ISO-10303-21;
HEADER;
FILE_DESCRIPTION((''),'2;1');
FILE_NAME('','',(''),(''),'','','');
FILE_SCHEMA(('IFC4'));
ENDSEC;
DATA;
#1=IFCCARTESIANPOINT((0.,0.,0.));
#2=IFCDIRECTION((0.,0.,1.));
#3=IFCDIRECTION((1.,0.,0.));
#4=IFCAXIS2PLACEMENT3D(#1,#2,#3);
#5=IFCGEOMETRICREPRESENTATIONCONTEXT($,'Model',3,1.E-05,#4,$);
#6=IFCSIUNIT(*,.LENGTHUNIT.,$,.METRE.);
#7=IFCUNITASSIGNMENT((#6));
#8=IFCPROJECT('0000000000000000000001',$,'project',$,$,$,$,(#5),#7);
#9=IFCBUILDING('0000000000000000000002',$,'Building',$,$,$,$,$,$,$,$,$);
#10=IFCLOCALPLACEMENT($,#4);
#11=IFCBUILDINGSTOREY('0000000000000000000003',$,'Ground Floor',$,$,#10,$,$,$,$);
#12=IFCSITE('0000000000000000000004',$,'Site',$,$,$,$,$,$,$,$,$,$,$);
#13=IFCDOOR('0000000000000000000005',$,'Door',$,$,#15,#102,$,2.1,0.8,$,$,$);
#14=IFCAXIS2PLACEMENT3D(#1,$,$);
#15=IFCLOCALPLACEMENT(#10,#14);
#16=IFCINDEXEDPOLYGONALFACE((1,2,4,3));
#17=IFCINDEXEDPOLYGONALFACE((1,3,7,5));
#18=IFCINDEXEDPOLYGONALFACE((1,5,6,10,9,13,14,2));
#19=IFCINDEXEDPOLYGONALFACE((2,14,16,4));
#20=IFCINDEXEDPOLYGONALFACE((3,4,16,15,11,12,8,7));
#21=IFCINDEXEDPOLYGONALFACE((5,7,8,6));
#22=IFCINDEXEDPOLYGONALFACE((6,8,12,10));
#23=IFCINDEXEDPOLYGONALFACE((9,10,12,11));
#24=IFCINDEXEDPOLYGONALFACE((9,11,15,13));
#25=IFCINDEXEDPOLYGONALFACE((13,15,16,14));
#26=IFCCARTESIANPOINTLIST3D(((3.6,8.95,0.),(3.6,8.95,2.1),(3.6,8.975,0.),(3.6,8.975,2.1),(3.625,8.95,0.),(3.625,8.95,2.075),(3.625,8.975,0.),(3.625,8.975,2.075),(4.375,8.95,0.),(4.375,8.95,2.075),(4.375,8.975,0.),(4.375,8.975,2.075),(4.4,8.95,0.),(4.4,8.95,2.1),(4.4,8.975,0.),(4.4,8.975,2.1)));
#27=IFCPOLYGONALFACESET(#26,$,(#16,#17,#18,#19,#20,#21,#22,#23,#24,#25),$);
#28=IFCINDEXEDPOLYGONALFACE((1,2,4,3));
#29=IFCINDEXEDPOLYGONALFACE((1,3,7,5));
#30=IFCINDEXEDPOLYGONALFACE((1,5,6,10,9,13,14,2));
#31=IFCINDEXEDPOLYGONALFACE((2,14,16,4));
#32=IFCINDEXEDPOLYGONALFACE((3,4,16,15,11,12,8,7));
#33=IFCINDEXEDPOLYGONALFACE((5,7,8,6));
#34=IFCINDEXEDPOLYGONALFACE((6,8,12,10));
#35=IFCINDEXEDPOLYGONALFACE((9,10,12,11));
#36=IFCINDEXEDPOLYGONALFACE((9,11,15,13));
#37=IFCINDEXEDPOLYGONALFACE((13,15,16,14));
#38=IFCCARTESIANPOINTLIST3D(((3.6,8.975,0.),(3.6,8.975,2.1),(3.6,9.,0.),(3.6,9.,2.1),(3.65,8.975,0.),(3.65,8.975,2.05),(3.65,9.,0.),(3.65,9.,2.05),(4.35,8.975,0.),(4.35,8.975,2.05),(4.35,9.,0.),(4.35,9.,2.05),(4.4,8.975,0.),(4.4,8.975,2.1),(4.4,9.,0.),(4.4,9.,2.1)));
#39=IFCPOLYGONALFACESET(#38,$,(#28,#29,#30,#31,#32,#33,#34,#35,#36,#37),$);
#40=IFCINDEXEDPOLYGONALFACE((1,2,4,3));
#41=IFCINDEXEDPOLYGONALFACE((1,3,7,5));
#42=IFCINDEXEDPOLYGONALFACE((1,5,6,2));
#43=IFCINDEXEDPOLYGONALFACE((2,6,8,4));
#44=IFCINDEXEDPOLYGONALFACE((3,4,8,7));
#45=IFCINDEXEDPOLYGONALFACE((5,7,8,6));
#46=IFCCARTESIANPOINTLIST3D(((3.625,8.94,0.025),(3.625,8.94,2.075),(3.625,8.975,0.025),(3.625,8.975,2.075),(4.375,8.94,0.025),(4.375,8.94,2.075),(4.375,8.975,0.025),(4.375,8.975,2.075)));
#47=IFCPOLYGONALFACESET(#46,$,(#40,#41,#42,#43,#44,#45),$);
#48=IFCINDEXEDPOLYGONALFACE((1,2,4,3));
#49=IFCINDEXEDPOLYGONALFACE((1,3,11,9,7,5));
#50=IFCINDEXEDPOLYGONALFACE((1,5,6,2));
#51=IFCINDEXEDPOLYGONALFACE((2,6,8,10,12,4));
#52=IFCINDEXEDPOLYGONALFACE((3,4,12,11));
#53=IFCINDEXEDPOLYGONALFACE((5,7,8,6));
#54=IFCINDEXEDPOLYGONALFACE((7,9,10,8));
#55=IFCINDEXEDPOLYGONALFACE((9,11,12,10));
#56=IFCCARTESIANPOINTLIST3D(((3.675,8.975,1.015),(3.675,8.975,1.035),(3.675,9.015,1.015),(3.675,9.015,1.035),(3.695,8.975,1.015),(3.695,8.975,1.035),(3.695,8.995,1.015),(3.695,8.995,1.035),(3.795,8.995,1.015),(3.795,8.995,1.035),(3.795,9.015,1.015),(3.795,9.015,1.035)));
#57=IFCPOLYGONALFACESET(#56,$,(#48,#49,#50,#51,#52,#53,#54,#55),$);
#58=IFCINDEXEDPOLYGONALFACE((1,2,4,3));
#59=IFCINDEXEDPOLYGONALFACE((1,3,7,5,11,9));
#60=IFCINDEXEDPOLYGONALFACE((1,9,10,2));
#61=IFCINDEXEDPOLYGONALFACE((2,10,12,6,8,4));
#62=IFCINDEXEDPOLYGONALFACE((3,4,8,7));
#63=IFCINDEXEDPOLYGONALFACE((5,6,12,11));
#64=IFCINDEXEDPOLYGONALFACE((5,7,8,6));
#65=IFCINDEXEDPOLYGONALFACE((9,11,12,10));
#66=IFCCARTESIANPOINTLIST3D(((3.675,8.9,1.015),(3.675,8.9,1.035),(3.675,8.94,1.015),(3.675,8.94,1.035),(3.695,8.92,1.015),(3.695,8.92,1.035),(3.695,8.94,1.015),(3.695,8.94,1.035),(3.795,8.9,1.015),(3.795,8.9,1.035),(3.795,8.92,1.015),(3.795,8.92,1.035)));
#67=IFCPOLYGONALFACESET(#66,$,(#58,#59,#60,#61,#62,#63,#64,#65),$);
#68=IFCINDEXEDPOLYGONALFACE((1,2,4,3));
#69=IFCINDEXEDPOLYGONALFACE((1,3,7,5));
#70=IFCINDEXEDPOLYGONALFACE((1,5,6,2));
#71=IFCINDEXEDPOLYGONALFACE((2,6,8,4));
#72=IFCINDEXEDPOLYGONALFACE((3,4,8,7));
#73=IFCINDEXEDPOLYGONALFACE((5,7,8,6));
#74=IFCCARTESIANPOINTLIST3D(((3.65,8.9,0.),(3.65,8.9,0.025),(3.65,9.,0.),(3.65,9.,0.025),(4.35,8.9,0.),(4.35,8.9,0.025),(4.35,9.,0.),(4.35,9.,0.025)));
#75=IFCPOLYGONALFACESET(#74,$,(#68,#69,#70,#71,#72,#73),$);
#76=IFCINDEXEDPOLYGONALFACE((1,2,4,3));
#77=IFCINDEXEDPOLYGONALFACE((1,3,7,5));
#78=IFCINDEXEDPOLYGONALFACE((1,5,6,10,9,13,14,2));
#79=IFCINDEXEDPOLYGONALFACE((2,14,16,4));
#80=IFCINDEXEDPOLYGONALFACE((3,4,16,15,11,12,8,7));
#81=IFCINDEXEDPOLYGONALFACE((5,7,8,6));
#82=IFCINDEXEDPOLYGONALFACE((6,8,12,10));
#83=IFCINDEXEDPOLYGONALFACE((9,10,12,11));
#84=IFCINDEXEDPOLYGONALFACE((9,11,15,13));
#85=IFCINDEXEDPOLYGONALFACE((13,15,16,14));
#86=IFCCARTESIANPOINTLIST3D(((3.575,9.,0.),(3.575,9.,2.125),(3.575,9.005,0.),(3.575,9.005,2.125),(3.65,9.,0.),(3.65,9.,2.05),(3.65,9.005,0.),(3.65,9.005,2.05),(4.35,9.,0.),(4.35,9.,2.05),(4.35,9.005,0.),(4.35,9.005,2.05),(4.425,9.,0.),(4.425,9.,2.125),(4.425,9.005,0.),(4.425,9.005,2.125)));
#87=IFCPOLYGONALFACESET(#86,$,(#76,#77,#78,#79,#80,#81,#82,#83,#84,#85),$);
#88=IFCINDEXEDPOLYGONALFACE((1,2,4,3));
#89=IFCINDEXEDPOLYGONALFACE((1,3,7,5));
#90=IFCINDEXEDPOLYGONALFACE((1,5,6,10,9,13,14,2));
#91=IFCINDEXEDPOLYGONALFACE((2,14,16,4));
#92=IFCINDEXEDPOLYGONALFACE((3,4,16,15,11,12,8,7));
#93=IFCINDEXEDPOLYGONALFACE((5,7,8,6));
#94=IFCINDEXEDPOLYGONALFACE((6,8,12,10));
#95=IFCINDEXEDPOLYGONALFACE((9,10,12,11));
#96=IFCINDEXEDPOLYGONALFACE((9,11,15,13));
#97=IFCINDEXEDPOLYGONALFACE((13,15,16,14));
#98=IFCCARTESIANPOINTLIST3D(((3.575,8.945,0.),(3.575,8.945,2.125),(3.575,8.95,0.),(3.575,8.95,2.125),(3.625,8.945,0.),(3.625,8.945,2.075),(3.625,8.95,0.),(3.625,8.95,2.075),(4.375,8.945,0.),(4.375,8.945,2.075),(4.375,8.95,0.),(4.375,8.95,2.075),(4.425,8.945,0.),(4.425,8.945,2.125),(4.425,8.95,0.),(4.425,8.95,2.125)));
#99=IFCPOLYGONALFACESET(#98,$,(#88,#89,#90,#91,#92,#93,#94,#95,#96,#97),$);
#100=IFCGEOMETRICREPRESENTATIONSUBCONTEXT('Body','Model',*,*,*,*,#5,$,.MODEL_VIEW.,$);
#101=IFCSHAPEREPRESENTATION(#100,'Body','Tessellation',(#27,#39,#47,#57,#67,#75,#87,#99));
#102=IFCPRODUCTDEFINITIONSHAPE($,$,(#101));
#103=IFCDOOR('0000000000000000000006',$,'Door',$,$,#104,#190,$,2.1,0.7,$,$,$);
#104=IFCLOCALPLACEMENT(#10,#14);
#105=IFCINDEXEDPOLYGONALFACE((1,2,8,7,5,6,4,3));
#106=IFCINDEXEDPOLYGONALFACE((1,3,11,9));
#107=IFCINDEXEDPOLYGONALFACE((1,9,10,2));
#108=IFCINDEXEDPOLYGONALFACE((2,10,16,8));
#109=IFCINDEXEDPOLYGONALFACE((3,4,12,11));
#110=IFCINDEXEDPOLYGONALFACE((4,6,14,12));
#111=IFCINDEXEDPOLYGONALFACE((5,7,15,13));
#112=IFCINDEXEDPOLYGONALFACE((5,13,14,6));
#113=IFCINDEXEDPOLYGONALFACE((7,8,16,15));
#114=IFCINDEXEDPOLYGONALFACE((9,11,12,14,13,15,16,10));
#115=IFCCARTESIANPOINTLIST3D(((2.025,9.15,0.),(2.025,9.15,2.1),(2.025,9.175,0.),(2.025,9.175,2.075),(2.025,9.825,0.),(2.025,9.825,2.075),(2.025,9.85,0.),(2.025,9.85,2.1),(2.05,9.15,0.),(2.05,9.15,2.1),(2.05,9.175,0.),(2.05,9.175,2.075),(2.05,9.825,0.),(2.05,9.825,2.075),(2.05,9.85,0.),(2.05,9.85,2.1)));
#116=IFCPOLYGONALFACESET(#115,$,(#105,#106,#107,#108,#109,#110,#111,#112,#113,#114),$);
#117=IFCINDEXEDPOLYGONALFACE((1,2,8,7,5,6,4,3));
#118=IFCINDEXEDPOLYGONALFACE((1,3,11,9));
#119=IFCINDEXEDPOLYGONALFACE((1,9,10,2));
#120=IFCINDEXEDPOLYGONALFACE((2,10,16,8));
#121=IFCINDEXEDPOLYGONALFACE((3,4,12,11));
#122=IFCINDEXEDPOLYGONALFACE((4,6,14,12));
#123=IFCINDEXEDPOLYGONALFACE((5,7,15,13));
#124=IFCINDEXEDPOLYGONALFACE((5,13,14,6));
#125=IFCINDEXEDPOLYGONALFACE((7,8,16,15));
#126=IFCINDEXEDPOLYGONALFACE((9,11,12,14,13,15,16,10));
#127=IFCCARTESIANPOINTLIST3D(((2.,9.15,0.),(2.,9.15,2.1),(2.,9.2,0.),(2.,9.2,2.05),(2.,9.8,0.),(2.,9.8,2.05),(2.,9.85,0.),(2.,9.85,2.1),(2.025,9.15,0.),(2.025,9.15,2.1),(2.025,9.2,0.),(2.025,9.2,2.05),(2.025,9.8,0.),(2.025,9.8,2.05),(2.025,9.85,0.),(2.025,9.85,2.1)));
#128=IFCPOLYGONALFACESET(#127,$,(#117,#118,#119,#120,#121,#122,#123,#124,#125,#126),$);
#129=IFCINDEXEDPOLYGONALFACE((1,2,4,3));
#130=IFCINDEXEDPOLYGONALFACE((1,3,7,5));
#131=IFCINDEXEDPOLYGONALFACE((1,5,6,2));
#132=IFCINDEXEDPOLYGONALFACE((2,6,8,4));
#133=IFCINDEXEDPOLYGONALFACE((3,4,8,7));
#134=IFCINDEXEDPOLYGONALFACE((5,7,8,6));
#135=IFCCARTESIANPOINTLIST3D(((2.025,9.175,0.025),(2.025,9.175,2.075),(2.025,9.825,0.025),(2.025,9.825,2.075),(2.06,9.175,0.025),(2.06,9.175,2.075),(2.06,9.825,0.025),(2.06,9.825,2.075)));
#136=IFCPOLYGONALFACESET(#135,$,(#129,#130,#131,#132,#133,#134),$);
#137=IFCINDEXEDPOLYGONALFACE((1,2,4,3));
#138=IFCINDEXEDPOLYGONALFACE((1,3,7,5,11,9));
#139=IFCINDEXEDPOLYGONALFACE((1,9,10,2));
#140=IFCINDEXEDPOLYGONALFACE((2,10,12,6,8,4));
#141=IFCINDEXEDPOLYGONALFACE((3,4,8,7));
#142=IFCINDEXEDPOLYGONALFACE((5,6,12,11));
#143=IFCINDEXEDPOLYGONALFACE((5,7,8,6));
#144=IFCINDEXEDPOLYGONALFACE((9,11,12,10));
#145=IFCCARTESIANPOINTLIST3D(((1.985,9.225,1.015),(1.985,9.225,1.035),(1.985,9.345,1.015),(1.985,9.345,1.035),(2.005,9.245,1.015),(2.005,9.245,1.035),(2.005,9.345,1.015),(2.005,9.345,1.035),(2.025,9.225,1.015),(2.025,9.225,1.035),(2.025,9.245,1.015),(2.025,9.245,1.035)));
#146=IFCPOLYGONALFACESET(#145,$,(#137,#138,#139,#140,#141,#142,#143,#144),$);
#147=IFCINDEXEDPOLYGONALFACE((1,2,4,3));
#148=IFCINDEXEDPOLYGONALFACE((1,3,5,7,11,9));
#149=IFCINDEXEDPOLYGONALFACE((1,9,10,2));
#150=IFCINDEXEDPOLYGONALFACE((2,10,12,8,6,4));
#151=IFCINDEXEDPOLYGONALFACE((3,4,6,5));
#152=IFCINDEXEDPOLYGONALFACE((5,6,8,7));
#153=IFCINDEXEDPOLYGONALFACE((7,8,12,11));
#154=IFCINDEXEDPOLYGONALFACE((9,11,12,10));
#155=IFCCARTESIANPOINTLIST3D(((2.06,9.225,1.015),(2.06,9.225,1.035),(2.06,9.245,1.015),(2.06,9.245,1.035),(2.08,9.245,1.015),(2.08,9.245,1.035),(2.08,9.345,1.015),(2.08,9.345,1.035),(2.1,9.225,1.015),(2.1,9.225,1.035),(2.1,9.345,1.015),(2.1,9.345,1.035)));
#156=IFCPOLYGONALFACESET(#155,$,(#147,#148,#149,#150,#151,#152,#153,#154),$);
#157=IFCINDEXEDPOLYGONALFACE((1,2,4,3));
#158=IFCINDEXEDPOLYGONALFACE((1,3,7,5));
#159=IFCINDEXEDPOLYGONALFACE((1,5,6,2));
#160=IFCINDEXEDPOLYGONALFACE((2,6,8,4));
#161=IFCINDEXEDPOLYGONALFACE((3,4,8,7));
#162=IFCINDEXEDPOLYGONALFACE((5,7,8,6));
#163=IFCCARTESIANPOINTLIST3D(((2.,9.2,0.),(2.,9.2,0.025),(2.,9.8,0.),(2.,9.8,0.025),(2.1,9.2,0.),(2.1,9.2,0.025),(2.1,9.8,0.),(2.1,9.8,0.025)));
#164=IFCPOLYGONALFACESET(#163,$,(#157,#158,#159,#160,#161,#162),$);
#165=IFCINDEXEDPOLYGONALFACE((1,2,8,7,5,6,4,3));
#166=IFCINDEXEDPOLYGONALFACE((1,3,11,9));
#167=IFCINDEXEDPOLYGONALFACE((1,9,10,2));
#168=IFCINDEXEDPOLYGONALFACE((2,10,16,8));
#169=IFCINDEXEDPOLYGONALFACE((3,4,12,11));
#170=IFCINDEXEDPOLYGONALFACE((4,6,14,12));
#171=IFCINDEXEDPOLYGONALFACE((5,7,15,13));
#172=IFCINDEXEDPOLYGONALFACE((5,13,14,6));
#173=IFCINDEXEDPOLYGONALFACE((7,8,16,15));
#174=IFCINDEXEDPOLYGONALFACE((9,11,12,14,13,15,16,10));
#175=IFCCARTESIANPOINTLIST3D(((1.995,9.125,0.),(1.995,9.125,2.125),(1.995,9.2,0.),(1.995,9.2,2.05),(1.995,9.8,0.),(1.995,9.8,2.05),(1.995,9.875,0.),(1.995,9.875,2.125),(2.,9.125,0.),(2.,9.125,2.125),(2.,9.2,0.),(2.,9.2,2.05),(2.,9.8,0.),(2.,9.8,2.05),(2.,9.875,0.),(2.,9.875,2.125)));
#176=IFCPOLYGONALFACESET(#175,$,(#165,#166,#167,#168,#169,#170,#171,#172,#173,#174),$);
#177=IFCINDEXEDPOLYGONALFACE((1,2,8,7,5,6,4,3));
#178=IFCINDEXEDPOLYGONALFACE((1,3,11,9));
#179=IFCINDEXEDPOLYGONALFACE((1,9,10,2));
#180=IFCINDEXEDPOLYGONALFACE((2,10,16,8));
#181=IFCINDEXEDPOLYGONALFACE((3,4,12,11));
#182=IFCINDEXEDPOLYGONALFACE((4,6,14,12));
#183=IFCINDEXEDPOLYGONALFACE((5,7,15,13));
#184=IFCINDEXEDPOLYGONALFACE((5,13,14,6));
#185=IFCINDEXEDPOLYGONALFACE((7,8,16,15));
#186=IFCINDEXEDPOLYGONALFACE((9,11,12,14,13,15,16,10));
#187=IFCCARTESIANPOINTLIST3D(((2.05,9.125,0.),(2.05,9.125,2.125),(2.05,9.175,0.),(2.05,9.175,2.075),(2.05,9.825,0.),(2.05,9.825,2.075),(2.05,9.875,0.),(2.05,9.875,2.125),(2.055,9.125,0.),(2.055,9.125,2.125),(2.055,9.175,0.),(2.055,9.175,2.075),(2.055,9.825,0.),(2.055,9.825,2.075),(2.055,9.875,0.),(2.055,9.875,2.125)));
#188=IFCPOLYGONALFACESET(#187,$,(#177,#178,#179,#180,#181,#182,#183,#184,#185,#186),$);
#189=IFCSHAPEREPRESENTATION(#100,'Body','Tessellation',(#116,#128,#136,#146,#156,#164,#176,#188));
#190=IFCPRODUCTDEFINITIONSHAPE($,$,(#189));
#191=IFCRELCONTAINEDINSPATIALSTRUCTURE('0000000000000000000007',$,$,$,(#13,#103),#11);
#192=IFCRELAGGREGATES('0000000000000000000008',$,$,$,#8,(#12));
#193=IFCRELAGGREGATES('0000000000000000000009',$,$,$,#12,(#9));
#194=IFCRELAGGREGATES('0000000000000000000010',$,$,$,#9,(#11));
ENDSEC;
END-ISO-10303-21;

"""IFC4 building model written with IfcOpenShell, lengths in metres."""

from ifc_helpers import new_model, si_unit, frame, origin_with_axes, place, context, subcontext, project, spatial, line, indexed_curve, outline, extrude, element, save


model = new_model("IFC4")

# Units and contexts
model_context = context("Model", 3, precision=1e-05, world=origin_with_axes())
body_context = subcontext(model_context, "Body", "Model", "MODEL_VIEW")
ifc_project = project(units=[si_unit("LENGTHUNIT", "METRE")], contexts=[model_context])

# Site, building, storey
site = spatial("IfcSite", under=ifc_project, Name="Site")
building = spatial("IfcBuilding", under=site, Name="Building")
storey_placement = place(None, origin_with_axes())
storey = spatial("IfcBuildingStorey", under=building, at=storey_placement, Name="Ground Floor")

# Doors
door_1_placement = place(storey_placement, frame((4.4, 9.0, 0.0), z_axis=(0.0, 0.0, 1.0), x_axis=(-1.0, 0.0, 0.0)))
element("IfcDoor", 1, at=door_1_placement, inside=storey, Name="Door", OverallHeight=2.1, OverallWidth=0.8, context=body_context, shape_type="SweptSolid", body=[
    extrude(outline(indexed_curve([(0.0, 0.0), (0.0, 2.1), (0.8, 2.1), (0.8, 0.0), (0.775, 0.0), (0.775, 2.075), (0.025, 2.075), (0.025, 0.0)], segments=[line(1, 2, 3, 4, 5, 6, 7, 8, 1)])), frame((0.0, 0.025, 0.0), z_axis=(0.0, -1.0, 0.0), x_axis=(1.0, 0.0, 0.0)), (0.0, 0.0, -1.0), 0.025),
    extrude(outline(indexed_curve([(0.0, 0.0), (0.0, 2.1), (0.8, 2.1), (0.8, 0.0), (0.75, 0.0), (0.75, 2.05), (0.05, 2.05), (0.05, 0.0)], segments=[line(1, 2, 3, 4, 5, 6, 7, 8, 1)])), frame((0.0, 0.0, 0.0), z_axis=(0.0, -1.0, 0.0), x_axis=(1.0, 0.0, 0.0)), (0.0, 0.0, -1.0), 0.025),
    extrude(outline(indexed_curve([(0.0, 0.0), (0.75, 0.0), (0.75, 0.035), (0.0, 0.035)], segments=[line(1, 2, 3, 4, 1)])), frame((0.025, 0.025, 0.025), z_axis=(0.0, 0.0, 1.0), x_axis=(1.0, 0.0, 0.0)), (0.0, 0.0, 1.0), 2.05),
    extrude(outline(indexed_curve([(0.0, 0.0), (0.0, -0.04), (-0.12, -0.04), (-0.12, -0.02), (-0.02, -0.02), (-0.02, 0.0)], segments=[line(1, 2, 3, 4, 5, 6, 1)])), frame((0.725, 0.025, 1.015), z_axis=(0.0, 0.0, 1.0), x_axis=(1.0, 0.0, 0.0)), (0.0, 0.0, 1.0), 0.02),
    extrude(outline(indexed_curve([(0.0, 0.0), (0.0, 0.04), (-0.12, 0.04), (-0.12, 0.02), (-0.02, 0.02), (-0.02, 0.0)], segments=[line(1, 2, 3, 4, 5, 6, 1)])), frame((0.725, 0.06, 1.015), z_axis=(0.0, 0.0, 1.0), x_axis=(1.0, 0.0, 0.0)), (0.0, 0.0, 1.0), 0.02),
    extrude(outline(indexed_curve([(0.0, 0.0), (0.7, 0.0), (0.7, 0.1), (0.0, 0.1)], segments=[line(1, 2, 3, 4, 1)])), frame((0.05, 0.0, 0.0), z_axis=(0.0, 0.0, 1.0), x_axis=(1.0, 0.0, 0.0)), (0.0, 0.0, 1.0), 0.025),
    extrude(outline(indexed_curve([(0.0, 0.0), (0.0, 2.125), (0.85, 2.125), (0.85, 0.0), (0.775, 0.0), (0.775, 2.05), (0.075, 2.05), (0.075, 0.0)], segments=[line(1, 2, 3, 4, 5, 6, 7, 8, 1)])), frame((-0.025, -0.005, 0.0), z_axis=(0.0, -1.0, 0.0), x_axis=(1.0, 0.0, 0.0)), (0.0, 0.0, -1.0), 0.005),
    extrude(outline(indexed_curve([(0.0, 0.0), (0.0, 2.125), (0.85, 2.125), (0.85, 0.0), (0.8, 0.0), (0.8, 2.075), (0.05, 2.075), (0.05, 0.0)], segments=[line(1, 2, 3, 4, 5, 6, 7, 8, 1)])), frame((-0.025, 0.05, 0.0), z_axis=(0.0, -1.0, 0.0), x_axis=(1.0, 0.0, 0.0)), (0.0, 0.0, -1.0), 0.005),
])
door_2_placement = place(storey_placement, frame((2.0, 9.85, 0.0), z_axis=(0.0, 0.0, 1.0), x_axis=(0.0, -1.0, 0.0)))
element("IfcDoor", 2, at=door_2_placement, inside=storey, Name="Door", OverallHeight=2.1, OverallWidth=0.7, context=body_context, shape_type="SweptSolid", body=[
    extrude(outline(indexed_curve([(0.0, 0.0), (0.0, 2.1), (0.7, 2.1), (0.7, 0.0), (0.675, 0.0), (0.675, 2.075), (0.025, 2.075), (0.025, 0.0)], segments=[line(1, 2, 3, 4, 5, 6, 7, 8, 1)])), frame((0.0, 0.025, 0.0), z_axis=(0.0, -1.0, 0.0), x_axis=(1.0, 0.0, 0.0)), (0.0, 0.0, -1.0), 0.025),
    extrude(outline(indexed_curve([(0.0, 0.0), (0.0, 2.1), (0.7, 2.1), (0.7, 0.0), (0.65, 0.0), (0.65, 2.05), (0.05, 2.05), (0.05, 0.0)], segments=[line(1, 2, 3, 4, 5, 6, 7, 8, 1)])), frame((0.0, 0.0, 0.0), z_axis=(0.0, -1.0, 0.0), x_axis=(1.0, 0.0, 0.0)), (0.0, 0.0, -1.0), 0.025),
    extrude(outline(indexed_curve([(0.0, 0.0), (0.65, 0.0), (0.65, 0.035), (0.0, 0.035)], segments=[line(1, 2, 3, 4, 1)])), frame((0.025, 0.025, 0.025), z_axis=(0.0, 0.0, 1.0), x_axis=(1.0, 0.0, 0.0)), (0.0, 0.0, 1.0), 2.05),
    extrude(outline(indexed_curve([(0.0, 0.0), (0.0, -0.04), (-0.12, -0.04), (-0.12, -0.02), (-0.02, -0.02), (-0.02, 0.0)], segments=[line(1, 2, 3, 4, 5, 6, 1)])), frame((0.625, 0.025, 1.015), z_axis=(0.0, 0.0, 1.0), x_axis=(1.0, 0.0, 0.0)), (0.0, 0.0, 1.0), 0.02),
    extrude(outline(indexed_curve([(0.0, 0.0), (0.0, 0.04), (-0.12, 0.04), (-0.12, 0.02), (-0.02, 0.02), (-0.02, 0.0)], segments=[line(1, 2, 3, 4, 5, 6, 1)])), frame((0.625, 0.06, 1.015), z_axis=(0.0, 0.0, 1.0), x_axis=(1.0, 0.0, 0.0)), (0.0, 0.0, 1.0), 0.02),
    extrude(outline(indexed_curve([(0.0, 0.0), (0.6, 0.0), (0.6, 0.1), (0.0, 0.1)], segments=[line(1, 2, 3, 4, 1)])), frame((0.05, 0.0, 0.0), z_axis=(0.0, 0.0, 1.0), x_axis=(1.0, 0.0, 0.0)), (0.0, 0.0, 1.0), 0.025),
    extrude(outline(indexed_curve([(0.0, 0.0), (0.0, 2.125), (0.75, 2.125), (0.75, 0.0), (0.675, 0.0), (0.675, 2.05), (0.075, 2.05), (0.075, 0.0)], segments=[line(1, 2, 3, 4, 5, 6, 7, 8, 1)])), frame((-0.025, -0.005, 0.0), z_axis=(0.0, -1.0, 0.0), x_axis=(1.0, 0.0, 0.0)), (0.0, 0.0, -1.0), 0.005),
    extrude(outline(indexed_curve([(0.0, 0.0), (0.0, 2.125), (0.75, 2.125), (0.75, 0.0), (0.7, 0.0), (0.7, 2.075), (0.05, 2.075), (0.05, 0.0)], segments=[line(1, 2, 3, 4, 5, 6, 7, 8, 1)])), frame((-0.025, 0.05, 0.0), z_axis=(0.0, -1.0, 0.0), x_axis=(1.0, 0.0, 0.0)), (0.0, 0.0, -1.0), 0.005),
])

save(model, "model.ifc")
